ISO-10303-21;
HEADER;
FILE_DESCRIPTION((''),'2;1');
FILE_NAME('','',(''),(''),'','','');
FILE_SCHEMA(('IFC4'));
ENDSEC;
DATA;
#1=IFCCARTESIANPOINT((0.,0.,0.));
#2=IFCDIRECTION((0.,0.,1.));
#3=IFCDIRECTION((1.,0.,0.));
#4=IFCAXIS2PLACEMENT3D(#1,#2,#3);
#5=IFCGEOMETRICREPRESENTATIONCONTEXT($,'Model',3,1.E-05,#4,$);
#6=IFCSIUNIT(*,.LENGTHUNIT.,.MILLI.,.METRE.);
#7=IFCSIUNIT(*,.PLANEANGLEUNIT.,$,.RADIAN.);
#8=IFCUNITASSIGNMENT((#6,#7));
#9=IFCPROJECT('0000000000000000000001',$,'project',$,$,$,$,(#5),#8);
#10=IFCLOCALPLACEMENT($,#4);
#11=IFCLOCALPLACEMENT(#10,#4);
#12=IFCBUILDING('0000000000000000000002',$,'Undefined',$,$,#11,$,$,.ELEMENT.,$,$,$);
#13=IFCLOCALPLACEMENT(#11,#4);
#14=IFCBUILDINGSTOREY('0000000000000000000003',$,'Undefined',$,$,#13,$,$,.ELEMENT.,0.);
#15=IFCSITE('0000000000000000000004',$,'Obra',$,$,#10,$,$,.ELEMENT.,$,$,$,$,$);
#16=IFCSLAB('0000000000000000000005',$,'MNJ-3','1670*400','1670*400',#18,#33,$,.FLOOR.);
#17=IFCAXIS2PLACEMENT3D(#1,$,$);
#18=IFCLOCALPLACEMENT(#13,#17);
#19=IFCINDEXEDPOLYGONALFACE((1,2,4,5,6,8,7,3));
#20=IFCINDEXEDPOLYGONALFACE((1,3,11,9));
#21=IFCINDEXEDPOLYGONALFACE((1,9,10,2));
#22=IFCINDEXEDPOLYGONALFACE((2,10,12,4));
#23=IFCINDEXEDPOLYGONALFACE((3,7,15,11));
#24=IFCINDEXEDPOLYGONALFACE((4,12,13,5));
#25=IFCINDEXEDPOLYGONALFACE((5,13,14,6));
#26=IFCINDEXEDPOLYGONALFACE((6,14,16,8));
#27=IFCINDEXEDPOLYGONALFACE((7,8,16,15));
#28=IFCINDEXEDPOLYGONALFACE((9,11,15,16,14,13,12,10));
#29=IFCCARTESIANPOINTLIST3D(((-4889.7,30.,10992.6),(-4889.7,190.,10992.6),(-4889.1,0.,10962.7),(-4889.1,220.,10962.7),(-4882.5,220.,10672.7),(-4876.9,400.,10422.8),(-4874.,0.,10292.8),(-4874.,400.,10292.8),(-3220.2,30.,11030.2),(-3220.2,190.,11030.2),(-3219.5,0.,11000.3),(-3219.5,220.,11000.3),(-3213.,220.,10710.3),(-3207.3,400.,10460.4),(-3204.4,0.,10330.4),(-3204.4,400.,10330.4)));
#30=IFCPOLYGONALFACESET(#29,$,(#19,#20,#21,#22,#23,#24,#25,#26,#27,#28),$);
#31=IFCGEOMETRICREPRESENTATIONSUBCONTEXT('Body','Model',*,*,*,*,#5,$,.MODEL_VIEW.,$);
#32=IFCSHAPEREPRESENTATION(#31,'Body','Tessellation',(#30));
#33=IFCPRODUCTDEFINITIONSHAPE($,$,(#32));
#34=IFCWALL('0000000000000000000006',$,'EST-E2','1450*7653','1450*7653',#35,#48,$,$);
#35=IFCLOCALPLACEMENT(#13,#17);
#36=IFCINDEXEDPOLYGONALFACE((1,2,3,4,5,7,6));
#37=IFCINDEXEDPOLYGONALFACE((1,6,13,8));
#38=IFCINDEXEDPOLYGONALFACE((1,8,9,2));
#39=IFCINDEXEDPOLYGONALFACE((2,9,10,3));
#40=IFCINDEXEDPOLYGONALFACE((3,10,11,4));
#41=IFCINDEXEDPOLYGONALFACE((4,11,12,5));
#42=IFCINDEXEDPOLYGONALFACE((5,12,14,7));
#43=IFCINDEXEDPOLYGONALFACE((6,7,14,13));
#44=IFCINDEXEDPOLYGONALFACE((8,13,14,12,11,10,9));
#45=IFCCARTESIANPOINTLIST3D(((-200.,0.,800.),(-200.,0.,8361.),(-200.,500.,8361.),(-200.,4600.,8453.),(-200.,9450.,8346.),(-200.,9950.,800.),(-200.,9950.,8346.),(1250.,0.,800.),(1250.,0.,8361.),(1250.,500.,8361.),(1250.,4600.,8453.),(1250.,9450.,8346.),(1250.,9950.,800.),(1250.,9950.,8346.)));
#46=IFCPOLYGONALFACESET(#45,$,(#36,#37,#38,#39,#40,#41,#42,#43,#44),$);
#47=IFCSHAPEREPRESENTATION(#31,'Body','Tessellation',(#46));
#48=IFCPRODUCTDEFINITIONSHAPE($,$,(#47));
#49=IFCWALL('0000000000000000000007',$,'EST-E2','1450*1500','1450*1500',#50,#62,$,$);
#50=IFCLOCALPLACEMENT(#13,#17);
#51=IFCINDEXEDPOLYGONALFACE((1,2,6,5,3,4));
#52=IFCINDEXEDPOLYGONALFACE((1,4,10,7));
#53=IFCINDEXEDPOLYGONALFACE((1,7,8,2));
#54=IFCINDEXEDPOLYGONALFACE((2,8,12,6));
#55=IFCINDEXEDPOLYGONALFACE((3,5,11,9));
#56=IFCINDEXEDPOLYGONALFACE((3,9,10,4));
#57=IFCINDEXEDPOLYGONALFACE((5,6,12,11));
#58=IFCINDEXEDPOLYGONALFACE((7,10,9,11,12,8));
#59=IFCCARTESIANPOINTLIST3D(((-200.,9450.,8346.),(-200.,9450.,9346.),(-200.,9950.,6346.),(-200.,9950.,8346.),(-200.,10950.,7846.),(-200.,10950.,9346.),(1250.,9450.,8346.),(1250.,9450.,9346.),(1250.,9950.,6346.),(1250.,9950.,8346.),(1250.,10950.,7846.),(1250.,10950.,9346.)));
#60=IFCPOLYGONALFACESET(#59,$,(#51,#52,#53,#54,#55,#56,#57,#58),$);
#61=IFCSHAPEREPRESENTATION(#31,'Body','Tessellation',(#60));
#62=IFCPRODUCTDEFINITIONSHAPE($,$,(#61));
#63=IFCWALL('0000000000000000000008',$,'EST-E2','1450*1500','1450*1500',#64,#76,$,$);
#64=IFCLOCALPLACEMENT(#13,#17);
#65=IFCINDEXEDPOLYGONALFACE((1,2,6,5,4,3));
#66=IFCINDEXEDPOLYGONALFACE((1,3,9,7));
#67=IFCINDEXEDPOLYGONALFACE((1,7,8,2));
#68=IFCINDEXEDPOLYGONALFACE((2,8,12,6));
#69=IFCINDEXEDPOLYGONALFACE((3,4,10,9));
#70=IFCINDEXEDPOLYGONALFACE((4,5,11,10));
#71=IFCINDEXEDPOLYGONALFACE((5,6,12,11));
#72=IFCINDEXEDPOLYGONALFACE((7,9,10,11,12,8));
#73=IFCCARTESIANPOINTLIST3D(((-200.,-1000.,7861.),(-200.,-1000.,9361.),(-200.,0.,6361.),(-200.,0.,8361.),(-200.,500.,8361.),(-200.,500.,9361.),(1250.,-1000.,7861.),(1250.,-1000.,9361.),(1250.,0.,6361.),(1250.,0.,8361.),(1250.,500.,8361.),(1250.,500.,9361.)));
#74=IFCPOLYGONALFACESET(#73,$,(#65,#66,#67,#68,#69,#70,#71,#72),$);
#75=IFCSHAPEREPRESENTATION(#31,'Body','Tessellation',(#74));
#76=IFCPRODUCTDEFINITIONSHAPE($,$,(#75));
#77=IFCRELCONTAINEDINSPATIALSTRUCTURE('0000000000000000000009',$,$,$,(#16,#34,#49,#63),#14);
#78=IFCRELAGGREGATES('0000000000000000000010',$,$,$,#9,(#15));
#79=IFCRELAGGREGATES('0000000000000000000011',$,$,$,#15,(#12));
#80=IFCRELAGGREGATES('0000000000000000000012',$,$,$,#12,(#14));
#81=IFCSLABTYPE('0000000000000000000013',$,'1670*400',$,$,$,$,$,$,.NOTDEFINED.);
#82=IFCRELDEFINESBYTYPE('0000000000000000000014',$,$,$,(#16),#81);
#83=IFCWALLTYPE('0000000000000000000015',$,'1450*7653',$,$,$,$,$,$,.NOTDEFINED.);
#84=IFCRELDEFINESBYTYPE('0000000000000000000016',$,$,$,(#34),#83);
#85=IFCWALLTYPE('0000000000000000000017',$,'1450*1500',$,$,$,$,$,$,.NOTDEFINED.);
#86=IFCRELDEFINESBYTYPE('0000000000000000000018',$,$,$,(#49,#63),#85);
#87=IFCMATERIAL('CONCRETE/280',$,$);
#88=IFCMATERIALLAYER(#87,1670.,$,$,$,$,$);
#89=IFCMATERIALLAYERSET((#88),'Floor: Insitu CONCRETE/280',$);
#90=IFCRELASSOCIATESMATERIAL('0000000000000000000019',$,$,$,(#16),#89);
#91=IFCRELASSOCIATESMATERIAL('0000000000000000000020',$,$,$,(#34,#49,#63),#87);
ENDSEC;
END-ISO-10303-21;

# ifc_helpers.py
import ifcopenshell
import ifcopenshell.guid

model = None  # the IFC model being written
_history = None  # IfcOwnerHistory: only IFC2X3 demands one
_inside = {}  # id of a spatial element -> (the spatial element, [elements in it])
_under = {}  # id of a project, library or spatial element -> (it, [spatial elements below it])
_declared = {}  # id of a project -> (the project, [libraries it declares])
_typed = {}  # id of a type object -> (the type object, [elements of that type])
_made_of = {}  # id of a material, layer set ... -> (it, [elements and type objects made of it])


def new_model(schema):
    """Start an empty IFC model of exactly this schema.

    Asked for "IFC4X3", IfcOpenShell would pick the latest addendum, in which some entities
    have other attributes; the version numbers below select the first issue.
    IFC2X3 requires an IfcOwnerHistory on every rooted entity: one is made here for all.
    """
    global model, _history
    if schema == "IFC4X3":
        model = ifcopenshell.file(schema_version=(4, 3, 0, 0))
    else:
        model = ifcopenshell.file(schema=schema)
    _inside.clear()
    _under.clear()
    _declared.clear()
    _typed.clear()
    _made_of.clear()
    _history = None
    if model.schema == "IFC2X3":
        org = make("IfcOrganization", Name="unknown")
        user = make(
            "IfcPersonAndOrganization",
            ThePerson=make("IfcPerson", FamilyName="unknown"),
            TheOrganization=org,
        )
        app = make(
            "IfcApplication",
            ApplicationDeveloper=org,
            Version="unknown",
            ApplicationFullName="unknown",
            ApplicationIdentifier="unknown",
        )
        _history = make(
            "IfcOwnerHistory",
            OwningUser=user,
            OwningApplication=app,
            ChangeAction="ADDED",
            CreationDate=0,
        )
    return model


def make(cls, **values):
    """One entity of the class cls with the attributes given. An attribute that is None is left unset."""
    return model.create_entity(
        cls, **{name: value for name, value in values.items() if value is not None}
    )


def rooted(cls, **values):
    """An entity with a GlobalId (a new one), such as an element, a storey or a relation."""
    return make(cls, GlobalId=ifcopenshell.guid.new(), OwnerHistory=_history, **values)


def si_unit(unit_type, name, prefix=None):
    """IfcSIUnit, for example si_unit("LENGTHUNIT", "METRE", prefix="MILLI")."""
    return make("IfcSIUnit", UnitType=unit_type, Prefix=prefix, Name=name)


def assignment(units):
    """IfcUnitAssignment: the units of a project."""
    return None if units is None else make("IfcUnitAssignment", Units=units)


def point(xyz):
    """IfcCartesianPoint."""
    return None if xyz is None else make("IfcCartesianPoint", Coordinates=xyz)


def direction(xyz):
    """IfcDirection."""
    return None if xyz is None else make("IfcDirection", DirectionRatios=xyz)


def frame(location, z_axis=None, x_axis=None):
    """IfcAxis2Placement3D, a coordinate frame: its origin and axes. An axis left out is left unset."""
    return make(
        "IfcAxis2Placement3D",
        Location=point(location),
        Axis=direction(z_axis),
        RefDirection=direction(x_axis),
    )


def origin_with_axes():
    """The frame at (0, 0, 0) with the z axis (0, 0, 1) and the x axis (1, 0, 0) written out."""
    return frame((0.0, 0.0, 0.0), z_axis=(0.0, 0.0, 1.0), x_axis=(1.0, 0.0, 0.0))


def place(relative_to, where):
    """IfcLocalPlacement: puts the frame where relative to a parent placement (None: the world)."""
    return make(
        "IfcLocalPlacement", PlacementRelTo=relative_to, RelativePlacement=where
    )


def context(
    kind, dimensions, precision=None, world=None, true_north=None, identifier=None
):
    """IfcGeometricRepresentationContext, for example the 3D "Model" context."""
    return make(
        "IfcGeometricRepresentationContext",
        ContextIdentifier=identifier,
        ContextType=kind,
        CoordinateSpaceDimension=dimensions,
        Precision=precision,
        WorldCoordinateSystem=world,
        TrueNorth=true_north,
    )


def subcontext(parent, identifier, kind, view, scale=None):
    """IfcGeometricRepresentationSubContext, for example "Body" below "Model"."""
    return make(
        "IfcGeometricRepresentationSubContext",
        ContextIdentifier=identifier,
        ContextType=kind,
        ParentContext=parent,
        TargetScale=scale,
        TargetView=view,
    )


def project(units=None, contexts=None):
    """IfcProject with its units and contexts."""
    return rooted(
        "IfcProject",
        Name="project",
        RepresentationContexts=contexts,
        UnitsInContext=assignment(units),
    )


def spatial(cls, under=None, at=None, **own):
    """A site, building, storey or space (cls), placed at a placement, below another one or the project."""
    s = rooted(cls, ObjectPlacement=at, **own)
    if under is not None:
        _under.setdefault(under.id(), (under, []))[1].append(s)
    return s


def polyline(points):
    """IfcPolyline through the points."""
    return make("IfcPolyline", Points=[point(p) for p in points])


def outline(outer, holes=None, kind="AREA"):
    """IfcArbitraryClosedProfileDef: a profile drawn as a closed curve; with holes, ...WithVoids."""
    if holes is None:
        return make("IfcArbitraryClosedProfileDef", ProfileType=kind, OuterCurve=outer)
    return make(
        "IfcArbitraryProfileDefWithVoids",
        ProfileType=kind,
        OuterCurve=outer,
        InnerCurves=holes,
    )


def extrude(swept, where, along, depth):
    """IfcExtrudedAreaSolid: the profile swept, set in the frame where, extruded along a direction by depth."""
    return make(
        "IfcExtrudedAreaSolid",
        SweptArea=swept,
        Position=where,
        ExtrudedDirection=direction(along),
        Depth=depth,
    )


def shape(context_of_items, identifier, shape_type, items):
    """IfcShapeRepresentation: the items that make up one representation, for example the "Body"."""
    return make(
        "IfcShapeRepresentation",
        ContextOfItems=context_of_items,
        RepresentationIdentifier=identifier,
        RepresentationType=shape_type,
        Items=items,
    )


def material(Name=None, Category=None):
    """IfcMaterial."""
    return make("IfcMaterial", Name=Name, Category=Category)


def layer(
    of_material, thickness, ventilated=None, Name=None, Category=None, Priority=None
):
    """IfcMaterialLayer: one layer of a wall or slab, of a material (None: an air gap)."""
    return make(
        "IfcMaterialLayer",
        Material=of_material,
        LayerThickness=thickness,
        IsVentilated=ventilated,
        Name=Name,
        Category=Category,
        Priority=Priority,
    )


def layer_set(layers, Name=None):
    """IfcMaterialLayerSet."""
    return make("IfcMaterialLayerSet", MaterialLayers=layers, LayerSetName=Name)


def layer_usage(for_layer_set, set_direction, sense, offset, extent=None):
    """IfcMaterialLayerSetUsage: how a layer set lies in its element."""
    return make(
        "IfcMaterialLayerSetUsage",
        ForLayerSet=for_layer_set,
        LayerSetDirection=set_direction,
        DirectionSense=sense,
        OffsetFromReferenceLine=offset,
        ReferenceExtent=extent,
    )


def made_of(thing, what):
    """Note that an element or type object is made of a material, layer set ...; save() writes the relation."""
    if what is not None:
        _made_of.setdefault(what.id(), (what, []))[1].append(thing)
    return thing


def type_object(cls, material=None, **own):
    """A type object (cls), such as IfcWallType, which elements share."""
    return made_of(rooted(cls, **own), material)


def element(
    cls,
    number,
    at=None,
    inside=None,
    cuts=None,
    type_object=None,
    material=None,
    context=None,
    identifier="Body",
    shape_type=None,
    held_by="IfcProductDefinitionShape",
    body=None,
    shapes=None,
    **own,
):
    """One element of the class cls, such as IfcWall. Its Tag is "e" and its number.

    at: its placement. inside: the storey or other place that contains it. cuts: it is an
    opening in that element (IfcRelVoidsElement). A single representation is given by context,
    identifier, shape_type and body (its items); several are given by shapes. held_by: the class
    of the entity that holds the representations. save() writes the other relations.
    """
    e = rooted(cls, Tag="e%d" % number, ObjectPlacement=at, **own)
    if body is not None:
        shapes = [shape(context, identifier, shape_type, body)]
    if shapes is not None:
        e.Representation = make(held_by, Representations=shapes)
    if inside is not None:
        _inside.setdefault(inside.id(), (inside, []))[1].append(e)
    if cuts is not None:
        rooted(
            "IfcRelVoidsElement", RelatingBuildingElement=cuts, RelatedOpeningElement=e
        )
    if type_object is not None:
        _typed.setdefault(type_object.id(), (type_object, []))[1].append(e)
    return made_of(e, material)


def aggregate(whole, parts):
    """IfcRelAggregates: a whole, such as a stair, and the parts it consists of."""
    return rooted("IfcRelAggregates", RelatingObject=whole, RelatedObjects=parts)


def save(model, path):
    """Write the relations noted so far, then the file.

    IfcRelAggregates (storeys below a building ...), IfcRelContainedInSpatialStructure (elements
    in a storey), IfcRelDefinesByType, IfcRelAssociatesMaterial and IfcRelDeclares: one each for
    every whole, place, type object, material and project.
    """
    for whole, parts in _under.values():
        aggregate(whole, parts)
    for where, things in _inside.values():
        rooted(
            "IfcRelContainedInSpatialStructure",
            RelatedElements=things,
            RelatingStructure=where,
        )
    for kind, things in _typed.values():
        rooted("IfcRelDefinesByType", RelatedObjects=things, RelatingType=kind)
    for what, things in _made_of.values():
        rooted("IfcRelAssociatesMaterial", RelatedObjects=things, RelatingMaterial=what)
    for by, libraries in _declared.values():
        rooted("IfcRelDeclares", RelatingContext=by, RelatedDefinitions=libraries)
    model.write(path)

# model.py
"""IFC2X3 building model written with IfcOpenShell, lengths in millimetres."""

from ifc_helpers import new_model, si_unit, frame, origin_with_axes, place, context, subcontext, project, spatial, polyline, outline, extrude, material, layer, layer_set, layer_usage, type_object, element, save


model = new_model("IFC2X3")

# Units and contexts
model_context = context("Model", 3, precision=1e-05, world=origin_with_axes())
body_context = subcontext(model_context, "Body", "Model", "MODEL_VIEW")
ifc_project = project(units=[si_unit("LENGTHUNIT", "METRE", prefix="MILLI"), si_unit("PLANEANGLEUNIT", "RADIAN")], contexts=[model_context])

# Site, building, storey
site_placement = place(None, origin_with_axes())
site = spatial("IfcSite", under=ifc_project, at=site_placement, Name="Obra", CompositionType="ELEMENT")
building_placement = place(site_placement, origin_with_axes())
building = spatial("IfcBuilding", under=site, at=building_placement, Name="Undefined", CompositionType="ELEMENT")
storey_placement = place(building_placement, origin_with_axes())
storey = spatial("IfcBuildingStorey", under=building, at=storey_placement, Name="Undefined", CompositionType="ELEMENT", Elevation=0.0)

# Shared definitions
ifc_material_1 = material(Name="CONCRETE/280")

# Slab
ifc_layer_1 = layer(ifc_material_1, 1670.0)
ifc_layer_set_1 = layer_set([ifc_layer_1], Name="Floor: Insitu CONCRETE/280")
slab_type_1 = type_object("IfcSlabType", Name="1670*400", PredefinedType="NOTDEFINED")
ifc_layer_usage_1 = layer_usage(ifc_layer_set_1, "AXIS3", "POSITIVE", -835.0)
slab_1_placement = place(storey_placement, frame((-4054.3, 0.0, 10981.5), z_axis=(0.999747, 0.0, 0.022513), x_axis=(0.022513, 0.0, -0.999747)))
element("IfcSlab", 1, at=slab_1_placement, inside=storey, type_object=slab_type_1, material=ifc_layer_usage_1, Name="MNJ-3", Description="1670*400", ObjectType="1670*400", PredefinedType="FLOOR", context=body_context, shape_type="SweptSolid", body=[
    extrude(outline(polyline([(0.0, 0.0), (670.0, 0.0), (670.0, 400.0), (540.0, 400.0), (290.0, 220.0), (0.0, 220.0), (-30.0, 190.0), (-30.0, 30.0), (0.0, 0.0)])), frame((0.0, 0.0, -835.0), z_axis=(0.0, 0.0, 1.0), x_axis=(1.0, 0.0, 0.0)), (0.0, 0.0, 1.0), 1670.0),
])

# Walls
wall_type_1 = type_object("IfcWallType", Name="1450*7653", PredefinedType="NOTDEFINED")
wall_placement = place(storey_placement, frame((525.0, 500.0, 8361.0), z_axis=(1.0, 0.0, 0.0), x_axis=(0.0, -1.0, 0.0)))
element("IfcWall", 2, at=wall_placement, inside=storey, type_object=wall_type_1, material=ifc_material_1, Name="EST-E2", Description="1450*7653", ObjectType="1450*7653", context=body_context, shape_type="SweptSolid", body=[
    extrude(outline(polyline([(0.0, 0.0), (500.0, 0.0), (500.0, 7561.0), (-9450.0, 7561.0), (-9450.0, 15.0), (-8950.0, 15.0), (-4100.0, -92.0), (0.0, 0.0)])), frame((0.0, 0.0, -725.0), z_axis=(0.0, 0.0, 1.0), x_axis=(1.0, 0.0, 0.0)), (0.0, 0.0, 1.0), 1450.0),
])
wall_type_2 = type_object("IfcWallType", Name="1450*1500", PredefinedType="NOTDEFINED")
for number, where, z_axis, x_axis, name in (
    (3, (525.0, 10950.0, 9346.0), (-1.0, 0.0, 0.0), (0.0, 0.0, -1.0), "EST-E2"),
    (4, (525.0, -1000.0, 9361.0), (1.0, 0.0, 0.0), (0.0, 0.0, -1.0), "EST-E2"),
):
    element("IfcWall", number, at=place(storey_placement, frame(where, z_axis=z_axis, x_axis=x_axis)), inside=storey, type_object=wall_type_2, material=ifc_material_1, Name=name, Description="1450*1500", ObjectType="1450*1500", context=body_context, shape_type="SweptSolid", body=[
        extrude(outline(polyline([(0.0, 0.0), (1500.0, 0.0), (3000.0, 1000.0), (1000.0, 1000.0), (1000.0, 1500.0), (0.0, 1500.0), (0.0, 0.0)])), frame((0.0, 0.0, -725.0), z_axis=(0.0, 0.0, 1.0), x_axis=(1.0, 0.0, 0.0)), (0.0, 0.0, 1.0), 1450.0),
    ])

save(model, "model.ifc")
